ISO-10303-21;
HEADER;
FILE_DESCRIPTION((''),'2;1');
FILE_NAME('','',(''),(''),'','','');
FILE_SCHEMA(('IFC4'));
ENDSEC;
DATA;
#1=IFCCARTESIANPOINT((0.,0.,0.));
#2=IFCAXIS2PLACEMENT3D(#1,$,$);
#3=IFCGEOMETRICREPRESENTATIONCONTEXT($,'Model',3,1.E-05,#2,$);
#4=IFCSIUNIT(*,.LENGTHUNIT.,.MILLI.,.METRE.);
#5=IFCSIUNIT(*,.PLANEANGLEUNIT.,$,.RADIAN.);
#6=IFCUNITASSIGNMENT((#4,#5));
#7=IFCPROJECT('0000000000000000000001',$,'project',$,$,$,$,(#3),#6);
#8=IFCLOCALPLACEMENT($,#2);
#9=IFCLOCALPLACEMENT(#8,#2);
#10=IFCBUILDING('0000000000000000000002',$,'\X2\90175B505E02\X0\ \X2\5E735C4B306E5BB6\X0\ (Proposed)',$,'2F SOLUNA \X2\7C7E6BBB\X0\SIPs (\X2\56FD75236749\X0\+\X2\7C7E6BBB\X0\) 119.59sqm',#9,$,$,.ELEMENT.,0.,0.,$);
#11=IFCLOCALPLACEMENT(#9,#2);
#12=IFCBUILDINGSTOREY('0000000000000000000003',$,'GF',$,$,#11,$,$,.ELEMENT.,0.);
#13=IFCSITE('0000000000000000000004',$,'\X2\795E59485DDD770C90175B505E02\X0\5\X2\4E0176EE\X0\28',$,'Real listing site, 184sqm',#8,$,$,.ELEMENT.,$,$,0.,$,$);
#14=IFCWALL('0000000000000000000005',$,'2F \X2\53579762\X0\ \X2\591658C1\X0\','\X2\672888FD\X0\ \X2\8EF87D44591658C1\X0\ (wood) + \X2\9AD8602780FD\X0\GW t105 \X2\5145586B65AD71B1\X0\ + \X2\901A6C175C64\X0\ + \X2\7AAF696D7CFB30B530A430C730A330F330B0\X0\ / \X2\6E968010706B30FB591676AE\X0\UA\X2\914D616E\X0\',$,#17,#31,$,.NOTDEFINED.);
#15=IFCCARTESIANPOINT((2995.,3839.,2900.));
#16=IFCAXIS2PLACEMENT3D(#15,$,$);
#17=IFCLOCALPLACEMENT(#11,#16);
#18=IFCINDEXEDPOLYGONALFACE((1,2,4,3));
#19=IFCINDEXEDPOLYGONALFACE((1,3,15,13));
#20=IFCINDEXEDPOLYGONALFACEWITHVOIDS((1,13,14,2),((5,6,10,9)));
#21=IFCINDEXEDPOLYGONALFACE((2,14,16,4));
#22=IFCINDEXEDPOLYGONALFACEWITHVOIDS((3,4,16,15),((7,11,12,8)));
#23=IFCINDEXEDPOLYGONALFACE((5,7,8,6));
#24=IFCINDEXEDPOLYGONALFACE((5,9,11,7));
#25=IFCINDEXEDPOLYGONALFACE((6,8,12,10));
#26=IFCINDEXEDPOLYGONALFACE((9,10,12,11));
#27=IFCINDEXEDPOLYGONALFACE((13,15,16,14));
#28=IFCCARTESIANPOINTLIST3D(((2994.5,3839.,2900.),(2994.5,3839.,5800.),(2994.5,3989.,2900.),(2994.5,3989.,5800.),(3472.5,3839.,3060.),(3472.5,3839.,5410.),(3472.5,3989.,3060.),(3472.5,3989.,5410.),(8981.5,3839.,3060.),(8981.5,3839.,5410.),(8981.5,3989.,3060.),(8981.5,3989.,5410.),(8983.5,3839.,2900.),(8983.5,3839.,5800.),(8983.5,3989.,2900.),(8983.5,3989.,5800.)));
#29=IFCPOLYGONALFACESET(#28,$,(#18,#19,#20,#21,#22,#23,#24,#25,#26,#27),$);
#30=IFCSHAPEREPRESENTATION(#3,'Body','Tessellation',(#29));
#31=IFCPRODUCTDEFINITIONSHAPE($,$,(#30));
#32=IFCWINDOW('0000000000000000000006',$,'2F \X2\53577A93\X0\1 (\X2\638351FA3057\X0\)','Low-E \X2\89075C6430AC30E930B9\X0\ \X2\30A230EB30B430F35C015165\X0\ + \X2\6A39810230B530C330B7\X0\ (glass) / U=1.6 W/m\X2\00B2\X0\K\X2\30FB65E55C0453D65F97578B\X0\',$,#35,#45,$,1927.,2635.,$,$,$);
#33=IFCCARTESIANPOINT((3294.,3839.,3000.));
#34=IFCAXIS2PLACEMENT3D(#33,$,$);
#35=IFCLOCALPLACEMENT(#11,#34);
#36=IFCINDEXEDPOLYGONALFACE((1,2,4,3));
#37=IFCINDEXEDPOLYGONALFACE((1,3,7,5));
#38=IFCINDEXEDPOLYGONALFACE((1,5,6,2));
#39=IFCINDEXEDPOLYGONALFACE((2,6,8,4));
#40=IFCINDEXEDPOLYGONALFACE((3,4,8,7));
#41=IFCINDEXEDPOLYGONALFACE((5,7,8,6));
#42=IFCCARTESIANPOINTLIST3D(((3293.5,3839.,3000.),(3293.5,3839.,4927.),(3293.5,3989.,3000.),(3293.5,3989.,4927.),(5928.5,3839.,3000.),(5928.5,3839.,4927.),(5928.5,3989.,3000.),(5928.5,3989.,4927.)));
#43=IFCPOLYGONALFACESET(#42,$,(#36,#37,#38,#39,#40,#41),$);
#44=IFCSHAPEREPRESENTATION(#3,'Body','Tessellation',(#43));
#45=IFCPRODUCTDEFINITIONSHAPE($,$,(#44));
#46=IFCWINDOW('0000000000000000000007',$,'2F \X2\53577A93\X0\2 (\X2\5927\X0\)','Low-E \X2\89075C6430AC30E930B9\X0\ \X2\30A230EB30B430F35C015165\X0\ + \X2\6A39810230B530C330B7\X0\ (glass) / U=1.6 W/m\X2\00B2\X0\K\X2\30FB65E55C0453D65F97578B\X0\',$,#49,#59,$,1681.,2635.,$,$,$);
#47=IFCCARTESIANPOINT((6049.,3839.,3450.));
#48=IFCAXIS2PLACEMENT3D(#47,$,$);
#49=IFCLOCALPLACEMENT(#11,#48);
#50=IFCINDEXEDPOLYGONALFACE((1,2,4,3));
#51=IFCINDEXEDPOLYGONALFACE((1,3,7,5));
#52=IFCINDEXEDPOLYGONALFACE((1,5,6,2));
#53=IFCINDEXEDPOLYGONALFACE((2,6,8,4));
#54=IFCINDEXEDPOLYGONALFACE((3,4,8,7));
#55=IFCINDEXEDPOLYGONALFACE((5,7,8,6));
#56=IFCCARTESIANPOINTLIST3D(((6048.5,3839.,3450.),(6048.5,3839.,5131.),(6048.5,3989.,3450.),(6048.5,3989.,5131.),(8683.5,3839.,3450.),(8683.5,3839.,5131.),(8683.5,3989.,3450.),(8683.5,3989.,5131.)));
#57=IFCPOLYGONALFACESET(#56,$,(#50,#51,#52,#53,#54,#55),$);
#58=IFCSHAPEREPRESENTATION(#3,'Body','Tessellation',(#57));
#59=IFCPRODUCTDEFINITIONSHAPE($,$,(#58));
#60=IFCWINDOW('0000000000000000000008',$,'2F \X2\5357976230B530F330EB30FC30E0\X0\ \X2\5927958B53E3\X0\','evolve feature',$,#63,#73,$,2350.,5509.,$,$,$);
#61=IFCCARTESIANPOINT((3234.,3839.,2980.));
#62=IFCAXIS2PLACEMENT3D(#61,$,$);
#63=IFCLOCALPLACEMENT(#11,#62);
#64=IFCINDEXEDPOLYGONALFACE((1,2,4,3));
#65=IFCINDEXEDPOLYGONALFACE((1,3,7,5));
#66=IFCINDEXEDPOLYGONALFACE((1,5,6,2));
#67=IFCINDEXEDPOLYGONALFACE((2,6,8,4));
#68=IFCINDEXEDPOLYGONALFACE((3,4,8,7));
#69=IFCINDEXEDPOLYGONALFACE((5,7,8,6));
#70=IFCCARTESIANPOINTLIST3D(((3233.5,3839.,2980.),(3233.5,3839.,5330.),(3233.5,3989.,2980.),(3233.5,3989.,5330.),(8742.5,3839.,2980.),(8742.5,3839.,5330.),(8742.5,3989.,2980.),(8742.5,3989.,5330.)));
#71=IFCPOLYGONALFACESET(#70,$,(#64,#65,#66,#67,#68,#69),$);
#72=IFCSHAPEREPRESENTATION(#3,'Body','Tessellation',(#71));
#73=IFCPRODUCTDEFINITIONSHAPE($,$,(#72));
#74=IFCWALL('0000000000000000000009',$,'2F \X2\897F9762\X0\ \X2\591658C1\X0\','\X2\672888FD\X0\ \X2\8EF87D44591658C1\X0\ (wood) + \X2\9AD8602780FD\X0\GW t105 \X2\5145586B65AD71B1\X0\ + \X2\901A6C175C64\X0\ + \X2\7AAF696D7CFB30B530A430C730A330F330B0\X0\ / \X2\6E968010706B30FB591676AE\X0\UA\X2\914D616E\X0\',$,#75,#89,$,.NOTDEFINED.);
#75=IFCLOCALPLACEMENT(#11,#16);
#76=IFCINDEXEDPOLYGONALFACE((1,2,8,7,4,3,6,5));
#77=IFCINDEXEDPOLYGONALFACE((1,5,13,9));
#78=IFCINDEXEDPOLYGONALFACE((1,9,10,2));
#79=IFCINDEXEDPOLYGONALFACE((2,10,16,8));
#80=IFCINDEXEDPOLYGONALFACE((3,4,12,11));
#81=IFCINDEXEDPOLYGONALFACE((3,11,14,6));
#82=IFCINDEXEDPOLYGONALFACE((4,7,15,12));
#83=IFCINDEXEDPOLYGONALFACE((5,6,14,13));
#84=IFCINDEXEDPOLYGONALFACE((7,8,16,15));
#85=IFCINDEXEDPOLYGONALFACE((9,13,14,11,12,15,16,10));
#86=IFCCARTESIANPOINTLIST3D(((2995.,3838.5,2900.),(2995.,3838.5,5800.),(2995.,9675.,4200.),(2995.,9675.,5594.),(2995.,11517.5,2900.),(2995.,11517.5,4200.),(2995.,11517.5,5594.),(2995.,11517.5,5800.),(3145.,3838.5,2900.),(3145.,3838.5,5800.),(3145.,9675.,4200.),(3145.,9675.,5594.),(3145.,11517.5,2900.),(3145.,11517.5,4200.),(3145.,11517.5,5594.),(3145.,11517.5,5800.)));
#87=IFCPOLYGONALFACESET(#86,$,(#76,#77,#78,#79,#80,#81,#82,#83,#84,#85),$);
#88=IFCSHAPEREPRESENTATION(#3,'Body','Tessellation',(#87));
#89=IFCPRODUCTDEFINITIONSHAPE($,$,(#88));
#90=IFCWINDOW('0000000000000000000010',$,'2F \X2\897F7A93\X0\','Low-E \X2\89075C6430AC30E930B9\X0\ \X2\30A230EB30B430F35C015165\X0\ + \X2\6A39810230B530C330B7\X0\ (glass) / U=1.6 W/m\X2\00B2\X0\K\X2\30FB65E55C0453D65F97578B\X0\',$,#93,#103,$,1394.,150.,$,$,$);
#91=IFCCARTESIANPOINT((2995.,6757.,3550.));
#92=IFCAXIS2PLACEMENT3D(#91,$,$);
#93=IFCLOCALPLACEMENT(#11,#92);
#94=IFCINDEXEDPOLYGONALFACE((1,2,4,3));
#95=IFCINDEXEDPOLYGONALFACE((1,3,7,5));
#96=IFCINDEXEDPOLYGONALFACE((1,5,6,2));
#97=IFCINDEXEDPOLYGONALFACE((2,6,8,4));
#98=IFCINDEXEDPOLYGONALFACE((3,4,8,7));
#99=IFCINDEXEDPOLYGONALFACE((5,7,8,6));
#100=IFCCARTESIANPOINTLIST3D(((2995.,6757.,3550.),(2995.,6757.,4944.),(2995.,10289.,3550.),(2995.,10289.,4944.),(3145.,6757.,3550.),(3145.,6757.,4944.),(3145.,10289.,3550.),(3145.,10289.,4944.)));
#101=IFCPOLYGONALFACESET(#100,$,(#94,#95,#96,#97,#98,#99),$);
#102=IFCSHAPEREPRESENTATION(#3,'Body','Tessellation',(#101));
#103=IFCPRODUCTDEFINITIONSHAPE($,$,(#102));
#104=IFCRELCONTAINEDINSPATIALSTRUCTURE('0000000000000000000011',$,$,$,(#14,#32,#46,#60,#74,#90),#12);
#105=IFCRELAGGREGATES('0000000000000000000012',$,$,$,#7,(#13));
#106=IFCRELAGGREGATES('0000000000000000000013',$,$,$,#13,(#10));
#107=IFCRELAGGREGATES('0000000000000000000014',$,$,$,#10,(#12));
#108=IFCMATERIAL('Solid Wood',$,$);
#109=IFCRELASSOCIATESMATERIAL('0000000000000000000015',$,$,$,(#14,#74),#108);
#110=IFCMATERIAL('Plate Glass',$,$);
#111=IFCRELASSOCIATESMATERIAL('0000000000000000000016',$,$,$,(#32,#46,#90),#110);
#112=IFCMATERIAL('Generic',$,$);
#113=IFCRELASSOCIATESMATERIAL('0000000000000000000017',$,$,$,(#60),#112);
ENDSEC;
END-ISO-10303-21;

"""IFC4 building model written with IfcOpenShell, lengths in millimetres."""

from ifc_helpers import new_model, si_unit, frame, frame_2d, origin, place, context, project, spatial, rectangle, extrude, material, element, fill, save


model = new_model("IFC4")

# Units and contexts
model_context = context("Model", 3, precision=1e-05, world=origin())
ifc_project = project(units=[si_unit("LENGTHUNIT", "METRE", prefix="MILLI"), si_unit("PLANEANGLEUNIT", "RADIAN")], contexts=[model_context])

# Site, building, storey
site_placement = place(None, origin())
site = spatial("IfcSite", under=ifc_project, at=site_placement, Name="神奈川県逗子市5丁目28", ObjectType="Real listing site, 184sqm", CompositionType="ELEMENT", RefElevation=0.0)
building_placement = place(site_placement, origin())
building = spatial("IfcBuilding", under=site, at=building_placement, Name="逗子市 平屋の家 (Proposed)", ObjectType="2F SOLUNA 籾殻SIPs (国産杉+籾殻) 119.59sqm", CompositionType="ELEMENT", ElevationOfRefHeight=0.0, ElevationOfTerrain=0.0)
storey_placement = place(building_placement, origin())
storey = spatial("IfcBuildingStorey", under=building, at=storey_placement, Name="GF", CompositionType="ELEMENT", Elevation=0.0)

# Shared definitions
ifc_material_1 = material(Name="Solid Wood")
ifc_material_2 = material(Name="Generic")

# Shared definitions
ifc_material_3 = material(Name="Plate Glass")

# Wall, openings, windows
wall_1_placement = place(storey_placement, frame((2995.0, 3839.0, 2900.0)))
wall_1 = element("IfcWall", 1, at=wall_1_placement, inside=storey, material=ifc_material_1, Name="2F 南面 外壁", Description="木製 軸組外壁 (wood) + 高性能GW t105 充填断熱 + 通気層 + 窯業系サイディング / 準耐火・外皮UA配慮", PredefinedType="NOTDEFINED", context=model_context, shape_type="SweptSolid", body=[
    extrude(rectangle(XDim=5989.0, YDim=150.0, at=frame_2d((2994.0, 75.0))), frame((2995.0, 3839.0, 2900.0)), (0.0, 0.0, 1.0), 2900.0),
])
opening_1_placement = place(storey_placement, frame((3294.0, 3839.0, 3000.0)))
opening_1 = element("IfcOpeningElement", 2, at=opening_1_placement, cuts=wall_1, PredefinedType="NOTDEFINED", context=model_context, shape_type="SweptSolid", body=[
    extrude(rectangle(XDim=2635.0, YDim=150.0, at=frame_2d((1317.0, 75.0))), frame((3294.0, 3839.0, 3000.0)), (0.0, 0.0, 1.0), 1927.0),
])
opening_2_placement = place(storey_placement, frame((6049.0, 3839.0, 3450.0)))
opening_2 = element("IfcOpeningElement", 3, at=opening_2_placement, cuts=wall_1, PredefinedType="NOTDEFINED", context=model_context, shape_type="SweptSolid", body=[
    extrude(rectangle(XDim=2635.0, YDim=150.0, at=frame_2d((1317.0, 75.0))), frame((6049.0, 3839.0, 3450.0)), (0.0, 0.0, 1.0), 1681.0),
])
opening_3_placement = place(storey_placement, frame((3234.0, 3839.0, 2980.0)))
opening_3 = element("IfcOpeningElement", 4, at=opening_3_placement, cuts=wall_1, PredefinedType="NOTDEFINED", context=model_context, shape_type="SweptSolid", body=[
    extrude(rectangle(XDim=5509.0, YDim=150.0, at=frame_2d((2754.0, 75.0))), frame((3234.0, 3839.0, 2980.0)), (0.0, 0.0, 1.0), 2350.0),
])
window_1_placement = place(storey_placement, frame((3294.0, 3839.0, 3000.0)))
window_1 = element("IfcWindow", 5, at=window_1_placement, inside=storey, material=ifc_material_3, Name="2F 南窓1 (掃出し)", Description="Low-E 複層ガラス アルゴン封入 + 樹脂サッシ (glass) / U=1.6 W/m²K・日射取得型", OverallHeight=1927.0, OverallWidth=2635.0, context=model_context, shape_type="SweptSolid", body=[
    extrude(rectangle(XDim=2635.0, YDim=150.0, at=frame_2d((1317.0, 75.0))), frame((3294.0, 3839.0, 3000.0)), (0.0, 0.0, 1.0), 1927.0),
])
fill(opening_1, window_1)
window_2_placement = place(storey_placement, frame((6049.0, 3839.0, 3450.0)))
window_2 = element("IfcWindow", 6, at=window_2_placement, inside=storey, material=ifc_material_3, Name="2F 南窓2 (大)", Description="Low-E 複層ガラス アルゴン封入 + 樹脂サッシ (glass) / U=1.6 W/m²K・日射取得型", OverallHeight=1681.0, OverallWidth=2635.0, context=model_context, shape_type="SweptSolid", body=[
    extrude(rectangle(XDim=2635.0, YDim=150.0, at=frame_2d((1317.0, 75.0))), frame((6049.0, 3839.0, 3450.0)), (0.0, 0.0, 1.0), 1681.0),
])
fill(opening_2, window_2)
window_3_placement = place(storey_placement, frame((3234.0, 3839.0, 2980.0)))
window_3 = element("IfcWindow", 7, at=window_3_placement, inside=storey, material=ifc_material_2, Name="2F 南面サンルーム 大開口", Description="evolve feature", OverallHeight=2350.0, OverallWidth=5509.0, context=model_context, shape_type="SweptSolid", body=[
    extrude(rectangle(XDim=5509.0, YDim=150.0, at=frame_2d((2754.0, 75.0))), frame((3234.0, 3839.0, 2980.0)), (0.0, 0.0, 1.0), 2350.0),
])
fill(opening_3, window_3)

# Wall, opening, window
wall_2_placement = place(storey_placement, frame((2995.0, 3839.0, 2900.0)))
wall_2 = element("IfcWall", 8, at=wall_2_placement, inside=storey, material=ifc_material_1, Name="2F 西面 外壁", Description="木製 軸組外壁 (wood) + 高性能GW t105 充填断熱 + 通気層 + 窯業系サイディング / 準耐火・外皮UA配慮", PredefinedType="NOTDEFINED", context=model_context, shape_type="SweptSolid", body=[
    extrude(rectangle(XDim=150.0, YDim=7679.0, at=frame_2d((75.0, 3839.0))), frame((2995.0, 3839.0, 2900.0)), (0.0, 0.0, 1.0), 2900.0),
])
opening_4_placement = place(storey_placement, frame((2995.0, 6757.0, 3550.0)))
opening_4 = element("IfcOpeningElement", 9, at=opening_4_placement, cuts=wall_2, PredefinedType="NOTDEFINED", context=model_context, shape_type="SweptSolid", body=[
    extrude(rectangle(XDim=150.0, YDim=3532.0, at=frame_2d((75.0, 1766.0))), frame((2995.0, 6757.0, 3550.0)), (0.0, 0.0, 1.0), 1394.0),
])
window_4_placement = place(storey_placement, frame((2995.0, 6757.0, 3550.0)))
window_4 = element("IfcWindow", 10, at=window_4_placement, inside=storey, material=ifc_material_3, Name="2F 西窓", Description="Low-E 複層ガラス アルゴン封入 + 樹脂サッシ (glass) / U=1.6 W/m²K・日射取得型", OverallHeight=1394.0, OverallWidth=150.0, context=model_context, shape_type="SweptSolid", body=[
    extrude(rectangle(XDim=150.0, YDim=3532.0, at=frame_2d((75.0, 1766.0))), frame((2995.0, 6757.0, 3550.0)), (0.0, 0.0, 1.0), 1394.0),
])
fill(opening_4, window_4)

save(model, "model.ifc")
